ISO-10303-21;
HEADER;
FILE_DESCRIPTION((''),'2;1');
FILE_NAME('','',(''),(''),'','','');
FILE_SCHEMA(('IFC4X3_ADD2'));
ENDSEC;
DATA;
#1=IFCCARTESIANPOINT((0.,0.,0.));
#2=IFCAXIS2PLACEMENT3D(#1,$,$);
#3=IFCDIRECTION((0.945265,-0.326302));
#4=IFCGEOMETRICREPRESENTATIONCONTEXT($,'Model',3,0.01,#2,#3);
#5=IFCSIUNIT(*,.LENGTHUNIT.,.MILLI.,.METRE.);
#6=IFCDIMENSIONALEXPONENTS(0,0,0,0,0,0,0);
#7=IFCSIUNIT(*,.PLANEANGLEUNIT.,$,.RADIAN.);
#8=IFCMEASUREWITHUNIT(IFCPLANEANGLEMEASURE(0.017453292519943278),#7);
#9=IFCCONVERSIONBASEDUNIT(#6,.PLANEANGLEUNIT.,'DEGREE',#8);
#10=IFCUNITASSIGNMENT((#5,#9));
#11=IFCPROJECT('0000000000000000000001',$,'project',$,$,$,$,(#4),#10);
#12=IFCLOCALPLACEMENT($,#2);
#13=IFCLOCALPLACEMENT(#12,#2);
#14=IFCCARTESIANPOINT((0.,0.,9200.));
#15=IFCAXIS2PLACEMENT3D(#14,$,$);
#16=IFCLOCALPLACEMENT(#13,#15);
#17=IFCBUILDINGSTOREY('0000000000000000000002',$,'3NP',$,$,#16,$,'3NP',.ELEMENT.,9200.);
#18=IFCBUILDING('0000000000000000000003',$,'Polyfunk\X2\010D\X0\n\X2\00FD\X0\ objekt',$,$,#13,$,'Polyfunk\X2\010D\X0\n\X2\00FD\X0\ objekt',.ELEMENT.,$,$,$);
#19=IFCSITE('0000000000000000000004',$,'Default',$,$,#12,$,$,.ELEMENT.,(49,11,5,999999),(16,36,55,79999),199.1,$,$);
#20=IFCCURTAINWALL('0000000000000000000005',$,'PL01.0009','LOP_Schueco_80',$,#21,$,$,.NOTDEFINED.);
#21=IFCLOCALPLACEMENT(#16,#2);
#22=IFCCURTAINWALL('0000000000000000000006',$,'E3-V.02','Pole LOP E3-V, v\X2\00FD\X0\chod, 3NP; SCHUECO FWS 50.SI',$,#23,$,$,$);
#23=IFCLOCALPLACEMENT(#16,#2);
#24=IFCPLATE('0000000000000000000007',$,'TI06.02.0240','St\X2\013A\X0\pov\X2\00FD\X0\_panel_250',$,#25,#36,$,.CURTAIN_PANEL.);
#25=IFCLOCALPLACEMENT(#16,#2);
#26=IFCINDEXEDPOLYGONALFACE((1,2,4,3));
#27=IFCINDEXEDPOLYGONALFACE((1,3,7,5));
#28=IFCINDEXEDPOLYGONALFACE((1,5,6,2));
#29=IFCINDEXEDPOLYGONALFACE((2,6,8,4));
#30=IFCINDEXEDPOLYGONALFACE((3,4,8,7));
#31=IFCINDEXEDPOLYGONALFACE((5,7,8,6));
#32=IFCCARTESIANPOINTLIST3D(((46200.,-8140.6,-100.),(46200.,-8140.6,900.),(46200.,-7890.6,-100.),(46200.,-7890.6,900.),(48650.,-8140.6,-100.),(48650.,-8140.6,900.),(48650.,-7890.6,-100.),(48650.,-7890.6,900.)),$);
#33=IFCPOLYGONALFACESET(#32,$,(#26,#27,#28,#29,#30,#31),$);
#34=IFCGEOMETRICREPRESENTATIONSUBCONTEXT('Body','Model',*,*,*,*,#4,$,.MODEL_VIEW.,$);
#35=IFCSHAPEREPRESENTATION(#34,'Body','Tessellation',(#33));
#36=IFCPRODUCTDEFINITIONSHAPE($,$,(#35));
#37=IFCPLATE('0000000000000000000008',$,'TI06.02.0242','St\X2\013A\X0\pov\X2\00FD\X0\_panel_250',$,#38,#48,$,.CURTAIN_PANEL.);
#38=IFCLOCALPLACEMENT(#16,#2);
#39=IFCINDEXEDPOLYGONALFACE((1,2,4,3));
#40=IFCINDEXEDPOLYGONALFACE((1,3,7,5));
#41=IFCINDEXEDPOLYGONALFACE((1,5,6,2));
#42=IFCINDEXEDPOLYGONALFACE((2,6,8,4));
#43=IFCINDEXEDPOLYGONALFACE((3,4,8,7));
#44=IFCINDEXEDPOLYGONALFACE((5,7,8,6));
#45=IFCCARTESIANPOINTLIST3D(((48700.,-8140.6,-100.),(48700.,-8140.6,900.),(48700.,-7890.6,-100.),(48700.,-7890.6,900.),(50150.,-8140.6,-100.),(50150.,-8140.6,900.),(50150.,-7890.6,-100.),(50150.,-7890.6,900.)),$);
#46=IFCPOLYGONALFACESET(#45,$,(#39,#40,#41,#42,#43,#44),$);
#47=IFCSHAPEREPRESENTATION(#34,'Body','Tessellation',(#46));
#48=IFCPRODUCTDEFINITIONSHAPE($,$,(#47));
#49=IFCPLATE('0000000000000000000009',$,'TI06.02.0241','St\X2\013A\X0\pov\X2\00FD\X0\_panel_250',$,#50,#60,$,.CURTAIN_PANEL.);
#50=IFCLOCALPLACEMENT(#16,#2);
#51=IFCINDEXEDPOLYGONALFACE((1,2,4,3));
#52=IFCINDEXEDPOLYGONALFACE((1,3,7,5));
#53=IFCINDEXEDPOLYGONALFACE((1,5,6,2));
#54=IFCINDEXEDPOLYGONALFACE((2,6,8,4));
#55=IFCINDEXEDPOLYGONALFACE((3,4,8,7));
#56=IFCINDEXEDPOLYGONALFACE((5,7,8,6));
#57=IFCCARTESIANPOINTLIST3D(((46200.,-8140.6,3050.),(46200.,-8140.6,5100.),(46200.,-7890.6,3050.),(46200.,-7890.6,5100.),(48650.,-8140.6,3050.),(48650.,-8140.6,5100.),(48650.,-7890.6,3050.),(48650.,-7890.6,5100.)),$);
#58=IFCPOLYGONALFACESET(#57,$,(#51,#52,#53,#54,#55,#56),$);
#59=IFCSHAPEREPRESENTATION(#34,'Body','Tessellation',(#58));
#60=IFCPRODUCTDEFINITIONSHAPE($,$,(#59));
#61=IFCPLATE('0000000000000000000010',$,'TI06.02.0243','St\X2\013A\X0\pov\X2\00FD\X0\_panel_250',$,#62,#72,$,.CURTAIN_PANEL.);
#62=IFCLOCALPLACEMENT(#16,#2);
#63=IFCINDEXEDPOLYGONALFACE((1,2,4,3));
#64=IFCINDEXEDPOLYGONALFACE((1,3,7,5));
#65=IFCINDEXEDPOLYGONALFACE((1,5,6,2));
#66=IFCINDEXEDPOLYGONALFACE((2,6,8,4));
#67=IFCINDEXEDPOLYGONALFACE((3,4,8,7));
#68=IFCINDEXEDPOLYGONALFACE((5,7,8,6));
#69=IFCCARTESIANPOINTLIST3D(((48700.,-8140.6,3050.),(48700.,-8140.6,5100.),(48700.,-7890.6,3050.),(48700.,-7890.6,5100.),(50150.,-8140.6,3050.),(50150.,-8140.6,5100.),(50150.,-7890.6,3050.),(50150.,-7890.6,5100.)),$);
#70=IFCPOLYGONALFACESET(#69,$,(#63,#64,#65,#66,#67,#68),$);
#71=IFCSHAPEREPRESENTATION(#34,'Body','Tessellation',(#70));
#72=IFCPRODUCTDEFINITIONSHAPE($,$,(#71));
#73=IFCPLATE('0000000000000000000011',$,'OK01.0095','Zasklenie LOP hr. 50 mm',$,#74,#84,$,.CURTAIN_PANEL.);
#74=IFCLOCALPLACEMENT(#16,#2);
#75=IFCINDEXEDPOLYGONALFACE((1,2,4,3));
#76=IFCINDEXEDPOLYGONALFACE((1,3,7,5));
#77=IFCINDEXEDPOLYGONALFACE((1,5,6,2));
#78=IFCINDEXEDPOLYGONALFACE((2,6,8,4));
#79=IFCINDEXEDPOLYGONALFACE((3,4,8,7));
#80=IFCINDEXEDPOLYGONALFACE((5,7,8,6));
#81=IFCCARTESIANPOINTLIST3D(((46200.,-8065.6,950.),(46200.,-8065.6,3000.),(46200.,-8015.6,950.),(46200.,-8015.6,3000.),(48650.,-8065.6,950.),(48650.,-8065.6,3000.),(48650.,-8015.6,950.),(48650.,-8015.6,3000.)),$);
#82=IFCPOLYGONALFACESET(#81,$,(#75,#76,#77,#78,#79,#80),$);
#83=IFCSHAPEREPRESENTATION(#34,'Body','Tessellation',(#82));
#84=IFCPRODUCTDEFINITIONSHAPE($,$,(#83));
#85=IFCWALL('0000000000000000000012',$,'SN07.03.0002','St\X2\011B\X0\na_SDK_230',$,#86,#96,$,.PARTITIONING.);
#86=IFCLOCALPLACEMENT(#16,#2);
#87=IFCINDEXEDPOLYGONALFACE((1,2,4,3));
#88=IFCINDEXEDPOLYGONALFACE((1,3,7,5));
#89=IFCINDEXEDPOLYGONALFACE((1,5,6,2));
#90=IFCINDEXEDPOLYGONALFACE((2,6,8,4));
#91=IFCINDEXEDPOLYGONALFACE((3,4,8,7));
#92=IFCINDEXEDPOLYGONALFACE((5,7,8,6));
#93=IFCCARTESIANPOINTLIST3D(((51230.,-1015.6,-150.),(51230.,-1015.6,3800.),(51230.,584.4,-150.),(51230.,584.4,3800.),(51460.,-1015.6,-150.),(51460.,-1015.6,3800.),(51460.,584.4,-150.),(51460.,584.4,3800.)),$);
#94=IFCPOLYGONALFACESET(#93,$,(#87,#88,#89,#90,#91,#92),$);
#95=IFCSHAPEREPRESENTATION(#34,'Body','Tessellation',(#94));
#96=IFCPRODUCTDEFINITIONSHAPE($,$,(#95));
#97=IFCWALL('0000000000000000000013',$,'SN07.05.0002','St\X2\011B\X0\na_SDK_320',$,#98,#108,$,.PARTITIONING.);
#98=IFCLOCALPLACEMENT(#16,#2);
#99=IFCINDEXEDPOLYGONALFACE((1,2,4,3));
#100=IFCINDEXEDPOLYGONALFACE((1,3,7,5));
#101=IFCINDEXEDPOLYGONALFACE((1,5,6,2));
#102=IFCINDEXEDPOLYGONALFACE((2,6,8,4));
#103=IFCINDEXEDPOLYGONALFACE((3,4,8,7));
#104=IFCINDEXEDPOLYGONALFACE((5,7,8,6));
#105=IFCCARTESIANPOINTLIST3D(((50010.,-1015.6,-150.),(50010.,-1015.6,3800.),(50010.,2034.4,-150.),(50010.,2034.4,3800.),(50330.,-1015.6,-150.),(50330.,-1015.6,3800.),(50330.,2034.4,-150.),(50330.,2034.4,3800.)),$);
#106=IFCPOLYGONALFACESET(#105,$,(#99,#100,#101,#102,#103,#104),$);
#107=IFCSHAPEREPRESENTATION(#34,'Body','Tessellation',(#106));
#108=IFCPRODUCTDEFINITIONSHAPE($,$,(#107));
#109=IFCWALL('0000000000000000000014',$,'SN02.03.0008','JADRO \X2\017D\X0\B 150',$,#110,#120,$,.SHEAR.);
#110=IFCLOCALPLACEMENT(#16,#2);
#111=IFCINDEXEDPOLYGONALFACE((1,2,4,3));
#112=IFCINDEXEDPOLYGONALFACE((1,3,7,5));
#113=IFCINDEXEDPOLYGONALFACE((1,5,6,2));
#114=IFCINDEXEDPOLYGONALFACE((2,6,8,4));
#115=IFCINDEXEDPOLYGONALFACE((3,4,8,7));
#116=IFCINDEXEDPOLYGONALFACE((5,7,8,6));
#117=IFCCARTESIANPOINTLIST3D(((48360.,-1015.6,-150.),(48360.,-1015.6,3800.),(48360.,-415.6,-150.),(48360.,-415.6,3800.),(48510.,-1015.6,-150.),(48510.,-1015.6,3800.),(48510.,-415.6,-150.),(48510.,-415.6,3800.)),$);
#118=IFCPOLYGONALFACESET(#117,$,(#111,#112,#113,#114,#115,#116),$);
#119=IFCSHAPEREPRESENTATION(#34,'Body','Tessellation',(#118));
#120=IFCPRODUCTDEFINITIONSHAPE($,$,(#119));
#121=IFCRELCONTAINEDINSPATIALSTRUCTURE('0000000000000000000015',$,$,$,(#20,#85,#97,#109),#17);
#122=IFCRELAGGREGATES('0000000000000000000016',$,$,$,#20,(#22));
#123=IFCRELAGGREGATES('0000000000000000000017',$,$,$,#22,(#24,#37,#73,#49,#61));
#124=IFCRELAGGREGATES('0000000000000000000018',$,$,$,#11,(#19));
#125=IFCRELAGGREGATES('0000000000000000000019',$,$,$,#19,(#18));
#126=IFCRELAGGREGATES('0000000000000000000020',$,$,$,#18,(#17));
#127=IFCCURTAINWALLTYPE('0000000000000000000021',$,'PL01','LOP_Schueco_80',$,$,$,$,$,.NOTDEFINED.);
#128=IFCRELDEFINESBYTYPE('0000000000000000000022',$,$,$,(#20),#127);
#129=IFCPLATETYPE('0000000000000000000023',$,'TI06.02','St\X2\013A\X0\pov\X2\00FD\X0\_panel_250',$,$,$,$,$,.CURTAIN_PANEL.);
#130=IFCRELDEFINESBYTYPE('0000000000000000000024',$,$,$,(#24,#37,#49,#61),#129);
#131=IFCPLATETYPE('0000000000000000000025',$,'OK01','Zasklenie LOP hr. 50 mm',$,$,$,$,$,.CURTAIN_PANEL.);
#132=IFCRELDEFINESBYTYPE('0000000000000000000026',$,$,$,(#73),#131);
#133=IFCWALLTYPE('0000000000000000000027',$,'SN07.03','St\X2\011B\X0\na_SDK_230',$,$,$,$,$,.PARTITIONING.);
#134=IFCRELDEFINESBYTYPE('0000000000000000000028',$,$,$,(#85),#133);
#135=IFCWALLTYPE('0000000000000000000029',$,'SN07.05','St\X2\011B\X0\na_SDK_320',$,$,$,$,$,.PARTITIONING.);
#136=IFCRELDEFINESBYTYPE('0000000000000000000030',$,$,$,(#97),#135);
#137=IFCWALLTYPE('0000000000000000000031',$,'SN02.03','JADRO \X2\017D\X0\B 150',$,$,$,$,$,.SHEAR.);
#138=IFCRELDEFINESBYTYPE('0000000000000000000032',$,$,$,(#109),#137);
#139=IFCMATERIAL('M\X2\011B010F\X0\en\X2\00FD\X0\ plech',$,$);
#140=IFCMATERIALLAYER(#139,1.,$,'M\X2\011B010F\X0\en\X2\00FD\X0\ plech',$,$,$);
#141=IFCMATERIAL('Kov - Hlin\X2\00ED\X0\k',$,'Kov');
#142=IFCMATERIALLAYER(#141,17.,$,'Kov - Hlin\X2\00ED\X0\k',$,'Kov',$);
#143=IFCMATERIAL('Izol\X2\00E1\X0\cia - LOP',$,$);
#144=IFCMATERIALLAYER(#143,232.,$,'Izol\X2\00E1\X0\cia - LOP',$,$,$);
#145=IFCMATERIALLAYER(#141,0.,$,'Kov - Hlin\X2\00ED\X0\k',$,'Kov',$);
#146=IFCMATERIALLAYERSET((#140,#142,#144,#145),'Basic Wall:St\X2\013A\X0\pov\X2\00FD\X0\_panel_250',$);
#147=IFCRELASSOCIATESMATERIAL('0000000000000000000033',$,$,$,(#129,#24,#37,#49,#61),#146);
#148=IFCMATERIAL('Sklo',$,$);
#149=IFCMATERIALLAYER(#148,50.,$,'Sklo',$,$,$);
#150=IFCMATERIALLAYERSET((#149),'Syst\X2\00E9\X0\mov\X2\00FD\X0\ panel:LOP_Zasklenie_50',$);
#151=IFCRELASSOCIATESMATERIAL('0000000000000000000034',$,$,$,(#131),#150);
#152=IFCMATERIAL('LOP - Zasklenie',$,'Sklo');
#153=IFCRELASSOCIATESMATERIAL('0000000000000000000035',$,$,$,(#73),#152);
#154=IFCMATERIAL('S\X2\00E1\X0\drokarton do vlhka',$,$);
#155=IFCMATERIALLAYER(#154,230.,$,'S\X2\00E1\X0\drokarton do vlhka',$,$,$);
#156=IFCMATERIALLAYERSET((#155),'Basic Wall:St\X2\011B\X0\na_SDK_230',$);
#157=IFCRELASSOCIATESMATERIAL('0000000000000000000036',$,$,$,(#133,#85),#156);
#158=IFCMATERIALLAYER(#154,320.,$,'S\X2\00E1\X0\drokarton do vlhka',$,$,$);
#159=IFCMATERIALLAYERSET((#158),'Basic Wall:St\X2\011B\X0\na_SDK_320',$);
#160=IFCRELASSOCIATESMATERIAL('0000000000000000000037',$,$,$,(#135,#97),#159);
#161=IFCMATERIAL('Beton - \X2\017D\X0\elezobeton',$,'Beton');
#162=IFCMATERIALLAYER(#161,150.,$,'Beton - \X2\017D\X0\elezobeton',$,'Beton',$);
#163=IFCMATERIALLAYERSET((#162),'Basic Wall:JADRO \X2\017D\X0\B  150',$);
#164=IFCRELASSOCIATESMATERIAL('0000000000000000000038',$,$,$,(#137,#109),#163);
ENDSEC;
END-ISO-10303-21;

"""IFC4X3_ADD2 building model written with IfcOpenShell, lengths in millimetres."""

from ifc_helpers import new_model, entity, si_unit, converted_unit, direction, frame, frame_2d, origin, origin_2d_with_axis, place, context, subcontext, project, spatial, polyline, rectangle, extrude, clip, bounded_halfspace, source, transform, mapped, material, layer, layer_set, layer_usage, type_object, type_shapes, element, aggregate, save


model = new_model("IFC4X3_ADD2")

# Units and contexts
model_context = context("Model", 3, precision=0.01, world=origin(), true_north=direction((0.945265, -0.326302)))
body_context = subcontext(model_context, "Body", "Model", "MODEL_VIEW")
ifc_project = project(units=[si_unit("LENGTHUNIT", "METRE", prefix="MILLI"), converted_unit("PLANEANGLEUNIT", "DEGREE", entity("IfcPlaneAngleMeasure", 0.017453292519943278), si_unit("PLANEANGLEUNIT", "RADIAN"), dimensions=[0, 0, 0, 0, 0, 0, 0])], contexts=[model_context])

# Site, building, storey
site_placement = place(None, origin())
site = spatial("IfcSite", under=ifc_project, at=site_placement, Name="Default", CompositionType="ELEMENT", RefLatitude=(49, 11, 5, 999999), RefLongitude=(16, 36, 55, 79999), RefElevation=199.1)
building_placement = place(site_placement, origin())
building = spatial("IfcBuilding", under=site, at=building_placement, Name="Polyfunkčný objekt", LongName="Polyfunkčný objekt", CompositionType="ELEMENT")
storey_placement = place(building_placement, frame((0.0, 0.0, 9200.0)))
storey = spatial("IfcBuildingStorey", under=building, at=storey_placement, Name="3NP", LongName="3NP", CompositionType="ELEMENT", Elevation=9200.0)

# Curtain walls, plates
curtain_wall_type = type_object("IfcCurtainWallType", Name="PL01", Description="LOP_Schueco_80", PredefinedType="NOTDEFINED")
curtain_wall_1_placement = place(storey_placement, frame((0.0, 0.0, -9200.0)))
curtain_wall_1 = element("IfcCurtainWall", 1, at=curtain_wall_1_placement, inside=storey, type_object=curtain_wall_type, Name="PL01.0009", Description="LOP_Schueco_80", PredefinedType="NOTDEFINED")
curtain_wall_2 = element("IfcCurtainWall", 2, Name="E3-V.02", Description="Pole LOP E3-V, východ, 3NP; SCHUECO FWS 50.SI")
aggregate(curtain_wall_1, [curtain_wall_2])
ifc_material_1 = material(Name="Měďený plech")
ifc_layer_1 = layer(ifc_material_1, 1.0, Name="Měďený plech")
ifc_material_2 = material(Name="Kov - Hliník", Category="Kov")
ifc_layer_2 = layer(ifc_material_2, 17.0, Name="Kov - Hliník", Category="Kov")
ifc_material_3 = material(Name="Izolácia - LOP")
ifc_layer_3 = layer(ifc_material_3, 232.0, Name="Izolácia - LOP")
ifc_layer_4 = layer(ifc_material_2, 0.0, Name="Kov - Hliník", Category="Kov")
ifc_layer_set_1 = layer_set([ifc_layer_1, ifc_layer_2, ifc_layer_3, ifc_layer_4], Name="Basic Wall:Stĺpový_panel_250")
ifc_layer_usage_1 = layer_usage(ifc_layer_set_1, "AXIS2", "POSITIVE", -125.0)
plate_type_1 = type_object("IfcPlateType", Name="TI06.02", Description="Stĺpový_panel_250", PredefinedType="CURTAIN_PANEL", material=ifc_layer_set_1)
plate_1_placement = place(storey_placement, frame((46200.0, -8015.6, -100.0)))
plate_1 = element("IfcPlate", 3, at=plate_1_placement, type_object=plate_type_1, material=ifc_layer_usage_1, Name="TI06.02.0240", Description="Stĺpový_panel_250", PredefinedType="CURTAIN_PANEL", context=body_context, shape_type="SweptSolid", body=[
    extrude(rectangle(XDim=250.0, YDim=2450.0, at=frame_2d((0.0, 0.0), x_axis=(1.0, 0.0))), frame((1225.0, 0.0, 0.0), z_axis=(0.0, 0.0, 1.0), x_axis=(0.0, 1.0, 0.0)), (0.0, 0.0, 1.0), 1000.0),
])
ifc_layer_usage_2 = layer_usage(ifc_layer_set_1, "AXIS2", "POSITIVE", -125.0)
plate_2_placement = place(storey_placement, frame((48700.0, -8015.6, -100.0)))
plate_2 = element("IfcPlate", 4, at=plate_2_placement, type_object=plate_type_1, material=ifc_layer_usage_2, Name="TI06.02.0242", Description="Stĺpový_panel_250", PredefinedType="CURTAIN_PANEL", context=body_context, shape_type="SweptSolid", body=[
    extrude(rectangle(XDim=250.0, YDim=1450.0, at=frame_2d((0.0, 0.0), x_axis=(1.0, 0.0))), frame((725.0, 0.0, 0.0), z_axis=(0.0, 0.0, 1.0), x_axis=(0.0, 1.0, 0.0)), (0.0, 0.0, 1.0), 1000.0),
])
ifc_layer_usage_3 = layer_usage(ifc_layer_set_1, "AXIS2", "POSITIVE", -125.0)
plate_3_placement = place(storey_placement, frame((46200.0, -8015.6, 3050.0)))
plate_3 = element("IfcPlate", 5, at=plate_3_placement, type_object=plate_type_1, material=ifc_layer_usage_3, Name="TI06.02.0241", Description="Stĺpový_panel_250", PredefinedType="CURTAIN_PANEL", context=body_context, shape_type="SweptSolid", body=[
    extrude(rectangle(XDim=250.0, YDim=2450.0, at=frame_2d((0.0, 0.0), x_axis=(1.0, 0.0))), frame((1225.0, 0.0, 0.0), z_axis=(0.0, 0.0, 1.0), x_axis=(0.0, 1.0, 0.0)), (0.0, 0.0, 1.0), 2050.0),
])
ifc_layer_usage_4 = layer_usage(ifc_layer_set_1, "AXIS2", "POSITIVE", -125.0)
plate_4_placement = place(storey_placement, frame((48700.0, -8015.6, 3050.0)))
plate_4 = element("IfcPlate", 6, at=plate_4_placement, type_object=plate_type_1, material=ifc_layer_usage_4, Name="TI06.02.0243", Description="Stĺpový_panel_250", PredefinedType="CURTAIN_PANEL", context=body_context, shape_type="SweptSolid", body=[
    extrude(rectangle(XDim=250.0, YDim=1450.0, at=frame_2d((0.0, 0.0), x_axis=(1.0, 0.0))), frame((725.0, 0.0, 0.0), z_axis=(0.0, 0.0, 1.0), x_axis=(0.0, 1.0, 0.0)), (0.0, 0.0, 1.0), 2050.0),
])
ifc_material_4 = material(Name="LOP - Zasklenie", Category="Sklo")
ifc_material_5 = material(Name="Sklo")
ifc_layer_5 = layer(ifc_material_5, 50.0, Name="Sklo")
ifc_layer_set_2 = layer_set([ifc_layer_5], Name="Systémový panel:LOP_Zasklenie_50")
plate_type_2 = type_object("IfcPlateType", Name="OK01", Description="Zasklenie LOP hr. 50 mm", PredefinedType="CURTAIN_PANEL", material=ifc_layer_set_2)
shared_shape_1 = source(origin(), body_context, "Body", "SweptSolid", [
    extrude(rectangle(XDim=50.0, YDim=2450.0, at=origin_2d_with_axis()), frame((0.0, -25.0, 0.0), z_axis=(0.0, 0.0, 1.0), x_axis=(0.0, 1.0, 0.0)), (0.0, 0.0, 1.0), 2050.0),
])
type_shapes(plate_type_2, [shared_shape_1])
plate_5_placement = place(curtain_wall_1_placement, frame((47425.0, -8015.6, 10150.0)))
plate_5 = element("IfcPlate", 7, at=plate_5_placement, type_object=plate_type_2, material=ifc_material_4, Name="OK01.0095", Description="Zasklenie LOP hr. 50 mm", PredefinedType="CURTAIN_PANEL", context=body_context, shape_type="MappedRepresentation", body=[
    mapped(shared_shape_1, transform((0.0, 0.0, 0.0), scale=1.0)),
])
aggregate(curtain_wall_2, [plate_1, plate_2, plate_5, plate_3, plate_4])

# Walls
ifc_material_6 = material(Name="Sádrokarton do vlhka")
ifc_layer_6 = layer(ifc_material_6, 230.0, Name="Sádrokarton do vlhka")
ifc_layer_set_3 = layer_set([ifc_layer_6], Name="Basic Wall:Stěna_SDK_230")
wall_type_1 = type_object("IfcWallType", Name="SN07.03", Description="Stěna_SDK_230", PredefinedType="PARTITIONING", material=ifc_layer_set_3)
placement = place(building_placement, frame((0.0, 0.0, 5000.0)))
wall_1_placement = place(placement, frame((51345.0, 584.4, 4050.0), z_axis=(0.0, 0.0, 1.0), x_axis=(0.0, -1.0, 0.0)))
element("IfcWall", 8, at=wall_1_placement, inside=storey, type_object=wall_type_1, material=ifc_layer_set_3, Name="SN07.03.0002", Description="Stěna_SDK_230", PredefinedType="PARTITIONING", context=body_context, shape_type="Clipping", body=[
    clip(clip(extrude(rectangle(XDim=1600.0, YDim=230.0, at=frame_2d((800.0, 0.0), x_axis=(-1.0, 0.0))), origin(), (0.0, 0.0, 1.0), 3950.0), bounded_halfspace(frame((1600.0, -115.0, 0.0), z_axis=(0.0, 0.0, 1.0), x_axis=(0.0, -1.0, 0.0)), True, frame((1600.0, -115.0, 0.0)), polyline([(0.0, 0.0), (0.0, 230.0), (-1600.0, 230.0), (-1600.0, 0.0), (0.0, 0.0)]))), bounded_halfspace(frame((0.0, -115.0, 3950.0), z_axis=(0.0, 0.0, -1.0), x_axis=(0.0, 1.0, 0.0)), True, frame((0.0, -115.0, 3950.0)), polyline([(0.0, 0.0), (1600.0, 0.0), (1600.0, 230.0), (0.0, 230.0), (0.0, 0.0)]))),
])
ifc_layer_7 = layer(ifc_material_6, 320.0, Name="Sádrokarton do vlhka")
ifc_layer_set_4 = layer_set([ifc_layer_7], Name="Basic Wall:Stěna_SDK_320")
wall_type_2 = type_object("IfcWallType", Name="SN07.05", Description="Stěna_SDK_320", PredefinedType="PARTITIONING", material=ifc_layer_set_4)
wall_2_placement = place(placement, frame((50170.0, 2034.4, 4050.0), z_axis=(0.0, 0.0, 1.0), x_axis=(0.0, -1.0, 0.0)))
element("IfcWall", 9, at=wall_2_placement, inside=storey, type_object=wall_type_2, material=ifc_layer_set_4, Name="SN07.05.0002", Description="Stěna_SDK_320", PredefinedType="PARTITIONING", context=body_context, shape_type="Clipping", body=[
    clip(clip(extrude(rectangle(XDim=3050.0, YDim=320.0, at=frame_2d((1525.0, 0.0), x_axis=(-1.0, 0.0))), origin(), (0.0, 0.0, 1.0), 3950.0), bounded_halfspace(frame((3050.0, -160.0, 0.0), z_axis=(0.0, 0.0, 1.0), x_axis=(0.0, -1.0, 0.0)), True, frame((3050.0, -160.0, 0.0)), polyline([(0.0, 0.0), (0.0, 320.0), (-1600.0, 320.0), (-1750.0, 320.0), (-2900.0, 320.0), (-3050.0, 320.0), (-3050.0, 0.0), (0.0, 0.0)]))), bounded_halfspace(frame((0.0, -160.0, 3950.0), z_axis=(0.0, 0.0, -1.0), x_axis=(0.0, 1.0, 0.0)), True, frame((0.0, -160.0, 3950.0)), polyline([(0.0, 0.0), (3050.0, 0.0), (3050.0, 320.0), (1450.0, 320.0), (1300.0, 320.0), (150.0, 320.0), (0.0, 320.0), (0.0, 0.0)]))),
])
ifc_material_7 = material(Name="Beton - Železobeton", Category="Beton")
ifc_layer_8 = layer(ifc_material_7, 150.0, Name="Beton - Železobeton", Category="Beton")
ifc_layer_set_5 = layer_set([ifc_layer_8], Name="Basic Wall:JADRO ŽB  150")
wall_type_3 = type_object("IfcWallType", Name="SN02.03", Description="JADRO ŽB 150", PredefinedType="SHEAR", material=ifc_layer_set_5)
wall_3_placement = place(placement, frame((48435.0, -1015.6, 4050.0), z_axis=(0.0, 0.0, 1.0), x_axis=(0.0, 1.0, 0.0)))
element("IfcWall", 10, at=wall_3_placement, inside=storey, type_object=wall_type_3, material=ifc_layer_set_5, Name="SN02.03.0008", Description="JADRO ŽB 150", PredefinedType="SHEAR", context=body_context, shape_type="SweptSolid", body=[
    extrude(rectangle(XDim=600.0, YDim=150.0, at=frame_2d((300.0, 0.0), x_axis=(-1.0, 0.0))), origin(), (0.0, 0.0, 1.0), 3950.0),
])

save(model, "model.ifc")
